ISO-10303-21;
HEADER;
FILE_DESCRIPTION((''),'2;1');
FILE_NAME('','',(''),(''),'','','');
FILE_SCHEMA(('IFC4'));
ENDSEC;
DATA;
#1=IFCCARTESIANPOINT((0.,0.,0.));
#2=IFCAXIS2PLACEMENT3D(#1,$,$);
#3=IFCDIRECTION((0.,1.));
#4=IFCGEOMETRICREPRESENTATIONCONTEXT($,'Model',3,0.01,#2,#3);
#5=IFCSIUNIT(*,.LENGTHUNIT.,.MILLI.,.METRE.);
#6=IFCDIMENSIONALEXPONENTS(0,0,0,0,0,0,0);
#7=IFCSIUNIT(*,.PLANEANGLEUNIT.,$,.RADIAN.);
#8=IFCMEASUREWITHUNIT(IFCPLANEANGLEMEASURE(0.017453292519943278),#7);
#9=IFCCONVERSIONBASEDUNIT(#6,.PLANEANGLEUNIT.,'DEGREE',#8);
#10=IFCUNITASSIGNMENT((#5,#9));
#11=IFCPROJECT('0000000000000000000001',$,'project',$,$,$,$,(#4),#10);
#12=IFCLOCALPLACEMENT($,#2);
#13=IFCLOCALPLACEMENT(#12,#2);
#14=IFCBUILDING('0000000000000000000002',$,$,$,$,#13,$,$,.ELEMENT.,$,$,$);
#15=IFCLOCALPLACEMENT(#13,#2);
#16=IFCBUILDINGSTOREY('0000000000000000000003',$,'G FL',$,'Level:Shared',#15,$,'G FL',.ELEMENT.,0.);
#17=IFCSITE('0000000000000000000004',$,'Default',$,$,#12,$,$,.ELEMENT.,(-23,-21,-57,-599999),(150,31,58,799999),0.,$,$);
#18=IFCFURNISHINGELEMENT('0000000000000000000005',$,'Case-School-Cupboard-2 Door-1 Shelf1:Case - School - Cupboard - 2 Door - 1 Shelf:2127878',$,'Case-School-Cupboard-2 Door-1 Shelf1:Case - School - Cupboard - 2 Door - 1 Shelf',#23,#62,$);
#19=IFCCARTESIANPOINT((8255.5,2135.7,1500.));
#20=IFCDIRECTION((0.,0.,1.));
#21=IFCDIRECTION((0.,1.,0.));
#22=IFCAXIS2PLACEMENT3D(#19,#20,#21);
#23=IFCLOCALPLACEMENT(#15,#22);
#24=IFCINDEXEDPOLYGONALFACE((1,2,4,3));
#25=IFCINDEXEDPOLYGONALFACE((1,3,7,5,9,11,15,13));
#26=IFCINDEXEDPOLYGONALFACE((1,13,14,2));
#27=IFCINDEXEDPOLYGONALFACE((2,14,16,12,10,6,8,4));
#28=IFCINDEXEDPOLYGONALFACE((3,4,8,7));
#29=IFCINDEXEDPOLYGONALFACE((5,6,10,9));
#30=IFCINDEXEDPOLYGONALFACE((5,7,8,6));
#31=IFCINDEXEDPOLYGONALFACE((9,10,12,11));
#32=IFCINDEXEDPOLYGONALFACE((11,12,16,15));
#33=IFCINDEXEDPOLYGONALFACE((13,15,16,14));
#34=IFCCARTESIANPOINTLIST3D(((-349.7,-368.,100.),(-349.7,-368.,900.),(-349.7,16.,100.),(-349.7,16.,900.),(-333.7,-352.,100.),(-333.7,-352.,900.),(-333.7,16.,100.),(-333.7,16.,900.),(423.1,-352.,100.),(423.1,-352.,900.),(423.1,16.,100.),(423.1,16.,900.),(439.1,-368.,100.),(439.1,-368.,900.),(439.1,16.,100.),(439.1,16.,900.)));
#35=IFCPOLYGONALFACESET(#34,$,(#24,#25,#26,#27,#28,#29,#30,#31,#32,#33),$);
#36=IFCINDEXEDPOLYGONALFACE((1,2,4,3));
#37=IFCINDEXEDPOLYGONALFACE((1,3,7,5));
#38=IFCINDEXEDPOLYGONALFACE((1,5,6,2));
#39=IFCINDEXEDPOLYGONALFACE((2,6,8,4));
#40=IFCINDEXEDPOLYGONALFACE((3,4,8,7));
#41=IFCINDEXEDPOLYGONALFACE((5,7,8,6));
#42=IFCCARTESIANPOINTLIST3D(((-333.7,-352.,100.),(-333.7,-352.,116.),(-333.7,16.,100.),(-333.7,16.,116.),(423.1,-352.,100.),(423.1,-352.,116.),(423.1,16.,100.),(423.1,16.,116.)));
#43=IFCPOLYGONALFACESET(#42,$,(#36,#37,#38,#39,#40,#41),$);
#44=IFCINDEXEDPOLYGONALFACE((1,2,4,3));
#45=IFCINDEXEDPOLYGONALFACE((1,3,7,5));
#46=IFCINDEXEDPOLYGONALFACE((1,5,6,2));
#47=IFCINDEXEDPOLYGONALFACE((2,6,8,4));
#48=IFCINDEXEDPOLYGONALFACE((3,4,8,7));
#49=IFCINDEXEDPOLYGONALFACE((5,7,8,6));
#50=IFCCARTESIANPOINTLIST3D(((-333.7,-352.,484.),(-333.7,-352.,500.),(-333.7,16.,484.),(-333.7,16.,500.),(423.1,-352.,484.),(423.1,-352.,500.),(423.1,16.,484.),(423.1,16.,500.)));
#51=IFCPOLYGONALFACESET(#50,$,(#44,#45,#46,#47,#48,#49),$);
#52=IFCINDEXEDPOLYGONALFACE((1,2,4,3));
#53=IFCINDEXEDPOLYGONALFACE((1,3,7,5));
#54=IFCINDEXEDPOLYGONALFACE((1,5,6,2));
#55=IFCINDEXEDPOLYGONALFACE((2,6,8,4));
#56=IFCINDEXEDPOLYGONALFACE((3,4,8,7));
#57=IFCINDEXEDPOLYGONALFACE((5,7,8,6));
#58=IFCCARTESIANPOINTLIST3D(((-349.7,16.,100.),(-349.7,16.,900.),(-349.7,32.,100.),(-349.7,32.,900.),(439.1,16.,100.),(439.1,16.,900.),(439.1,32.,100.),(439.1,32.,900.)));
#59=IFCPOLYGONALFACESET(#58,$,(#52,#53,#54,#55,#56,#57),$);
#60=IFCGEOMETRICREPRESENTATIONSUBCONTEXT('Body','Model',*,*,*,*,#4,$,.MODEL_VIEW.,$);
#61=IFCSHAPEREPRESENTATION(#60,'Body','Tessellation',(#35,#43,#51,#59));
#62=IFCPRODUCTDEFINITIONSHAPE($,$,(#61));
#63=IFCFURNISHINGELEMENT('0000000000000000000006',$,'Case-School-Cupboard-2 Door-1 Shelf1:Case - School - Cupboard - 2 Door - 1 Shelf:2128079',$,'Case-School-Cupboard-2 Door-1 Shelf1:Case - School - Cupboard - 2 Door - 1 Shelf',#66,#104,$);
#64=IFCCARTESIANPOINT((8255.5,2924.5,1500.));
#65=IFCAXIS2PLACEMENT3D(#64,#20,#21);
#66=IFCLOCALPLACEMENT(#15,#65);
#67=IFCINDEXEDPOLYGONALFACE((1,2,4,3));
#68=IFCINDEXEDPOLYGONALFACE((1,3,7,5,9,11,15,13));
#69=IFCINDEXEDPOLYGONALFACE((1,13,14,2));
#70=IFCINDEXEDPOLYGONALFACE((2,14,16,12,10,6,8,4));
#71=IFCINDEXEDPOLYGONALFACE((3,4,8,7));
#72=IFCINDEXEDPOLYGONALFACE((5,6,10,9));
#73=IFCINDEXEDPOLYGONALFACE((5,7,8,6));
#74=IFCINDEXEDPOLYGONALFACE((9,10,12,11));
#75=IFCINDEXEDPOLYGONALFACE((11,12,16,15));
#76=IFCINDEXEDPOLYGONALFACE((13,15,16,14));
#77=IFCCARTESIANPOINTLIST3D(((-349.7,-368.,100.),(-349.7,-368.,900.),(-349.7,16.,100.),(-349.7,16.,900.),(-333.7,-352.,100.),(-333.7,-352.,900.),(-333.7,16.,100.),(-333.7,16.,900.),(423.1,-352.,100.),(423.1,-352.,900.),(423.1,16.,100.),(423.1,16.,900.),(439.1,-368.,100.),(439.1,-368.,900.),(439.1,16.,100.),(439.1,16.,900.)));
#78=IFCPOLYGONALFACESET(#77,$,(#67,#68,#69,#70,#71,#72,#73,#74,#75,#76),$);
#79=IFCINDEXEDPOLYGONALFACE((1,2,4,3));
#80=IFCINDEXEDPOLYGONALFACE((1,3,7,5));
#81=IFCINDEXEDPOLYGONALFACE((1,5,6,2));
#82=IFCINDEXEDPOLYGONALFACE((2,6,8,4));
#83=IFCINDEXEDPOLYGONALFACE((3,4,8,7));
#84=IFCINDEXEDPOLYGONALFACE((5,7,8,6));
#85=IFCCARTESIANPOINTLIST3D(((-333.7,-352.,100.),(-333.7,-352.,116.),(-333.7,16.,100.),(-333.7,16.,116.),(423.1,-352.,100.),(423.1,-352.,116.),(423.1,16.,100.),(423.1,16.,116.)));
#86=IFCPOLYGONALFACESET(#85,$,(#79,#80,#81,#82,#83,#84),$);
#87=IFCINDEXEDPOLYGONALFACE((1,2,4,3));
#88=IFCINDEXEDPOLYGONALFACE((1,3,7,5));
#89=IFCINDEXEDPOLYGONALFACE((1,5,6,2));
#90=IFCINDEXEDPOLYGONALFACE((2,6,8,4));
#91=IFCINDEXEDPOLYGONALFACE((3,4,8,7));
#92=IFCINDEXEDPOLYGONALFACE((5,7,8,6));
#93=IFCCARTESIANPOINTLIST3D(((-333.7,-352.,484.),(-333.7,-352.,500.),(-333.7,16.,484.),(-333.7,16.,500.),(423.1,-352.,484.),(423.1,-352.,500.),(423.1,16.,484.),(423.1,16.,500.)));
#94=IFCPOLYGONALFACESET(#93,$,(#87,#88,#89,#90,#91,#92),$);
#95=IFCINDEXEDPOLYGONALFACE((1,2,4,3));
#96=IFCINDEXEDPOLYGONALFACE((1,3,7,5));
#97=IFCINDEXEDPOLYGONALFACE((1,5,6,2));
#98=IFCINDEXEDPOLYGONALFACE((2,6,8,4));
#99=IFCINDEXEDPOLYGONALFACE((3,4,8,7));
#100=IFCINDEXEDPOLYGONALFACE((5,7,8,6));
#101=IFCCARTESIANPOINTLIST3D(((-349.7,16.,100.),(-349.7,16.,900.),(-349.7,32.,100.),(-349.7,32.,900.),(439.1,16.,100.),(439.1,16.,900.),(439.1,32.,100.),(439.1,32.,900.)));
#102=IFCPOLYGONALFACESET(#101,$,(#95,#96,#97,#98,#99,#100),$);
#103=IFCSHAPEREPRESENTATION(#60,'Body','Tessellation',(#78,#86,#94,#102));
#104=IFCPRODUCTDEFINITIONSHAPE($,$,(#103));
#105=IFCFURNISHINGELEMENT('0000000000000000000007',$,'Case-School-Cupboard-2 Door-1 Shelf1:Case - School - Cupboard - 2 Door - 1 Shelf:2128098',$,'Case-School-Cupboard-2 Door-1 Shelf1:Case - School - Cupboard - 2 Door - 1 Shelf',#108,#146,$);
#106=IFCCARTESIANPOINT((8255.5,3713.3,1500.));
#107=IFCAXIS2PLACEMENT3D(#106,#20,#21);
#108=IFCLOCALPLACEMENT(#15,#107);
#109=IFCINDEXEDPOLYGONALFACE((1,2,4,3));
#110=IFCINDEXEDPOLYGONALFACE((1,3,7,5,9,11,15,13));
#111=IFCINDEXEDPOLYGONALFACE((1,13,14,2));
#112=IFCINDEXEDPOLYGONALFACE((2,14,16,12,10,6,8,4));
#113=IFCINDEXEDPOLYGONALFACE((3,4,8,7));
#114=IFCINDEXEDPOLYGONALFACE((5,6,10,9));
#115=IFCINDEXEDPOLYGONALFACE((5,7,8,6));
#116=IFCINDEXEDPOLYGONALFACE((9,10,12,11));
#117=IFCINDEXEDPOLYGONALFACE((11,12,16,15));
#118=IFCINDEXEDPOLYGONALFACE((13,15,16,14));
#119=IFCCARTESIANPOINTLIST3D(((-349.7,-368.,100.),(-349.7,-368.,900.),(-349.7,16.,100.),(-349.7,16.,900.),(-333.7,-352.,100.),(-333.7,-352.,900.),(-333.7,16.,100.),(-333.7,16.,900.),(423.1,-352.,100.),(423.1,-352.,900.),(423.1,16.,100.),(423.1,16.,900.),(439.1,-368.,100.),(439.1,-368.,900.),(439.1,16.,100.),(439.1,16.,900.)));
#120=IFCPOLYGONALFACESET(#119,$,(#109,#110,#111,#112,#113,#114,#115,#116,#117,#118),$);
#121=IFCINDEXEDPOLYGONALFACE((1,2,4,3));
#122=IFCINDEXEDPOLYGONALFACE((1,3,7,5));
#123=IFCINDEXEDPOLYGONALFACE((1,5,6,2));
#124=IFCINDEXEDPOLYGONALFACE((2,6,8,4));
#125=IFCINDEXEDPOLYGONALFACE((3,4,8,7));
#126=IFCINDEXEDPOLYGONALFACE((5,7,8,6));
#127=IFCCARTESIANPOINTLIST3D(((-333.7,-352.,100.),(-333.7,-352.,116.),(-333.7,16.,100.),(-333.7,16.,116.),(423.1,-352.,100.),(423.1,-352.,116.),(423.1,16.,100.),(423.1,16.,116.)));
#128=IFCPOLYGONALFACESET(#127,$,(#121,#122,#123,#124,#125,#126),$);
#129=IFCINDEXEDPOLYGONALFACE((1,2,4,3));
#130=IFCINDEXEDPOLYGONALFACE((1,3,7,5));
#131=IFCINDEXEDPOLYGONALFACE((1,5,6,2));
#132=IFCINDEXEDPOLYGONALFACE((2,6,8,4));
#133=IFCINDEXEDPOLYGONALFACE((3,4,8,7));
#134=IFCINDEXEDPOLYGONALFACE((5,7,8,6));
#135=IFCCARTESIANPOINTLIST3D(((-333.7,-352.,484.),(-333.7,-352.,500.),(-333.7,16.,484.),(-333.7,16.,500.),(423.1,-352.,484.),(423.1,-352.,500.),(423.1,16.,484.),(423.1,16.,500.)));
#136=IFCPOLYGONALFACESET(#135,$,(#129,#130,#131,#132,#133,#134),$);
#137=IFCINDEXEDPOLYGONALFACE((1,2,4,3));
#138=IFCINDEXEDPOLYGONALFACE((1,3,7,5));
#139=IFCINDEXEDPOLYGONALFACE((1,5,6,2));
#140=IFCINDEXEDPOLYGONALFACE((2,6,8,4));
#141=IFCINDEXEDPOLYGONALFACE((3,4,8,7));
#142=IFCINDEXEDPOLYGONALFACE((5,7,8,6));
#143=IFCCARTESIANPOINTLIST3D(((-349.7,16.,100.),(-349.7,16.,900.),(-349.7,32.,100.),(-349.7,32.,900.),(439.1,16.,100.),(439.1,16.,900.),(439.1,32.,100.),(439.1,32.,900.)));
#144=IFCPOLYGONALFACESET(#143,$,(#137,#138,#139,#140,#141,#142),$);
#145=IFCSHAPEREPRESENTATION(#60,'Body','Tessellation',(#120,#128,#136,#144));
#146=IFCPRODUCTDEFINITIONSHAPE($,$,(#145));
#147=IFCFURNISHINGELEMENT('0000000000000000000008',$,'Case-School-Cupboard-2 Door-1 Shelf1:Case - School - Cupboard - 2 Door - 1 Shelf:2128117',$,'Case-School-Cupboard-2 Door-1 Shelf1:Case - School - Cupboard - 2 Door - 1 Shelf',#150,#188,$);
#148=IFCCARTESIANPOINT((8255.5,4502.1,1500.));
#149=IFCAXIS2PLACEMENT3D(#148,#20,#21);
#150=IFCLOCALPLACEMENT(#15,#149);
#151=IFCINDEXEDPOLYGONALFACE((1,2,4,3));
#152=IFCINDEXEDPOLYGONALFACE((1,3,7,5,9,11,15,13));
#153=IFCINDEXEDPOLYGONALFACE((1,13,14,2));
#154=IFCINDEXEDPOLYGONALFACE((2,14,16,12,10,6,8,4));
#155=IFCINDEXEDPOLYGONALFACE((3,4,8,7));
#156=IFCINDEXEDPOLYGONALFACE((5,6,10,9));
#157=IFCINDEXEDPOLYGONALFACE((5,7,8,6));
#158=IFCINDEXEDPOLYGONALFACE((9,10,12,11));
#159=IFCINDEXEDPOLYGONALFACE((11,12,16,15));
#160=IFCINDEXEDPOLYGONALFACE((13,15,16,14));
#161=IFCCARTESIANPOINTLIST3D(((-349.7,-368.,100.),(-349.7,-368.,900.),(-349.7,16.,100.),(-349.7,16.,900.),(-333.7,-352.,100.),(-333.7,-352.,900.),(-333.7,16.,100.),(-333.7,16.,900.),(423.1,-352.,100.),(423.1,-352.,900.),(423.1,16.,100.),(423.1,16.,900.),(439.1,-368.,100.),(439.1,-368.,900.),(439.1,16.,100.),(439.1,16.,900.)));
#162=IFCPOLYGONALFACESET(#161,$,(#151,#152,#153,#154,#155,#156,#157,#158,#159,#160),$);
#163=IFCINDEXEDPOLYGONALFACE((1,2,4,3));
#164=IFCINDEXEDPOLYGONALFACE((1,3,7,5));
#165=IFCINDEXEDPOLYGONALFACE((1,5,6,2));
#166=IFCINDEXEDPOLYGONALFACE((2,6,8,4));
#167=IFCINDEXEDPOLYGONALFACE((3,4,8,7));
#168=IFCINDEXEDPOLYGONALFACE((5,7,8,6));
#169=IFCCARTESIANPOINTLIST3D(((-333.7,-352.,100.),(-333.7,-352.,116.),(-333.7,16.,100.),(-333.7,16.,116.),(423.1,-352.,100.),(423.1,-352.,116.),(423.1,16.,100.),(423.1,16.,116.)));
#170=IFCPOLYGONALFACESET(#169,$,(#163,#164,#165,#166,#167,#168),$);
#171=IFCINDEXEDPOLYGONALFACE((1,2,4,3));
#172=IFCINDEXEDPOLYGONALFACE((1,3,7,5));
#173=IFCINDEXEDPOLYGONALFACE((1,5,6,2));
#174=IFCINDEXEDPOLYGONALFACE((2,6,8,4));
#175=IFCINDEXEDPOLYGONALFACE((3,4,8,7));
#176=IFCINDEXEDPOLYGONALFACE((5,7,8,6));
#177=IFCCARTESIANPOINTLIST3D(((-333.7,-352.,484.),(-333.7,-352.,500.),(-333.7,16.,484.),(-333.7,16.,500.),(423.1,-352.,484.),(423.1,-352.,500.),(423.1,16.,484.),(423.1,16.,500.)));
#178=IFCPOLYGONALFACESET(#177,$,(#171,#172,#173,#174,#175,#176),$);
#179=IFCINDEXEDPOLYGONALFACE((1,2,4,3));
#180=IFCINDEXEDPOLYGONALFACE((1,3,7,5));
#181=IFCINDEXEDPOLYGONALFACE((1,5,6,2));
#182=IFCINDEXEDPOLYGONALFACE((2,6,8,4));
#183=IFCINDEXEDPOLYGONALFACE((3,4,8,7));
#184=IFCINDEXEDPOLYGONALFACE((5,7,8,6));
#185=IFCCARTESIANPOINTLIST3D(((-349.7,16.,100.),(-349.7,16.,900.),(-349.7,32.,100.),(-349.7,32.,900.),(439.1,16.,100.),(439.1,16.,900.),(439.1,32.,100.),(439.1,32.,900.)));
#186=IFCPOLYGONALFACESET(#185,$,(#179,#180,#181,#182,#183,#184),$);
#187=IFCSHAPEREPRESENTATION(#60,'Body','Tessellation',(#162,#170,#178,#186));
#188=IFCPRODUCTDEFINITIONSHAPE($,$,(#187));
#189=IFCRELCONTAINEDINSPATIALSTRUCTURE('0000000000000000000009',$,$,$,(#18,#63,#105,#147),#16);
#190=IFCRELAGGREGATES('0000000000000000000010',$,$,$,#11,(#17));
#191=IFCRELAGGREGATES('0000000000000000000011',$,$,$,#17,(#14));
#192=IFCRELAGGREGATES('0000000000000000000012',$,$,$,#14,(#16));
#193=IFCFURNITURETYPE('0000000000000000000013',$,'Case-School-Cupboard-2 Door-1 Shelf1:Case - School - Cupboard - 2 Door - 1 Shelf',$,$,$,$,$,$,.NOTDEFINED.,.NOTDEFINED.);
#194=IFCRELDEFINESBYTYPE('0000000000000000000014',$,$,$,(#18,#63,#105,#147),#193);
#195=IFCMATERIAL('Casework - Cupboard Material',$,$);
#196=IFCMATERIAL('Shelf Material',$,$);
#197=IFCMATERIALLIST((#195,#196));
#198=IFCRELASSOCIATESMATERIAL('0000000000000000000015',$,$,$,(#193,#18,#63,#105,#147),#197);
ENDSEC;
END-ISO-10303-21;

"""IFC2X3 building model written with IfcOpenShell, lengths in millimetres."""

from ifc_helpers import new_model, entity, si_unit, converted_unit, direction, frame, frame_2d, origin, place, context, subcontext, project, spatial, polyline, rectangle, outline, extrude, source, transform, mapped, material, material_list, type_object, type_shapes, element, save


model = new_model("IFC2X3")

# Units and contexts
model_context = context("Model", 3, precision=0.01, world=origin(), true_north=direction((0.0, 1.0)))
body_context = subcontext(model_context, "Body", "Model", "MODEL_VIEW")
ifc_project = project(units=[si_unit("LENGTHUNIT", "METRE", prefix="MILLI"), converted_unit("PLANEANGLEUNIT", "DEGREE", entity("IfcPlaneAngleMeasure", 0.017453292519943278), si_unit("PLANEANGLEUNIT", "RADIAN"), dimensions=[0, 0, 0, 0, 0, 0, 0])], contexts=[model_context])

# Site, building, storey
site_placement = place(None, origin())
site = spatial("IfcSite", under=ifc_project, at=site_placement, Name="Default", CompositionType="ELEMENT", RefLatitude=(-23, -21, -57, -599999), RefLongitude=(150, 31, 58, 799999), RefElevation=0.0)
building_placement = place(site_placement, origin())
building = spatial("IfcBuilding", under=site, at=building_placement, CompositionType="ELEMENT")
storey_placement = place(building_placement, origin())
storey = spatial("IfcBuildingStorey", under=building, at=storey_placement, Name="G FL", ObjectType="Level:Shared", LongName="G FL", CompositionType="ELEMENT", Elevation=0.0)

# Furnishing elements
ifc_material_1 = material(Name="Casework - Cupboard Material")
ifc_material_2 = material(Name="Shelf Material")
ifc_material_list = material_list([ifc_material_1, ifc_material_2])
furniture_type = type_object("IfcFurnitureType", Name="Case-School-Cupboard-2 Door-1 Shelf1:Case - School - Cupboard - 2 Door - 1 Shelf", AssemblyPlace="NOTDEFINED", material=ifc_material_list)
shared_shape_1 = source(origin(), body_context, "Body", "SweptSolid", [
    extrude(outline(polyline([(378.4, -188.0), (394.4, -188.0), (394.4, 196.0), (-394.4, 196.0), (-394.4, -188.0), (-378.4, -188.0), (-378.4, 180.0), (378.4, 180.0), (378.4, -188.0)])), frame((44.7, -172.0, 100.0), z_axis=(0.0, 0.0, 1.0), x_axis=(-1.0, 0.0, 0.0)), (0.0, 0.0, 1.0), 800.0),
    extrude(rectangle(XDim=368.0, YDim=756.8, at=frame_2d((0.0, 0.0), x_axis=(1.0, 0.0))), frame((44.7, -168.0, 100.0), z_axis=(0.0, 0.0, 1.0), x_axis=(0.0, -1.0, 0.0)), (0.0, 0.0, 1.0), 16.0),
    extrude(rectangle(XDim=756.8, YDim=368.0, at=frame_2d((0.0, 0.0), x_axis=(1.0, 0.0))), frame((44.7, -168.0, 484.0)), (0.0, 0.0, 1.0), 16.0),
    extrude(rectangle(XDim=788.8, YDim=16.0, at=frame_2d((0.0, 0.0), x_axis=(1.0, 0.0))), frame((44.7, 24.0, 100.0)), (0.0, 0.0, 1.0), 800.0),
])
type_shapes(furniture_type, [shared_shape_1])
for number, where, z_axis, x_axis, name in (
    (1, (8255.5, 2135.7, 1500.0), (0.0, 0.0, 1.0), (0.0, 1.0, 0.0), "Case-School-Cupboard-2 Door-1 Shelf1:Case - School - Cupboard - 2 Door - 1 Shelf:2127878"),
    (2, (8255.5, 2924.5, 1500.0), (0.0, 0.0, 1.0), (0.0, 1.0, 0.0), "Case-School-Cupboard-2 Door-1 Shelf1:Case - School - Cupboard - 2 Door - 1 Shelf:2128079"),
    (3, (8255.5, 3713.3, 1500.0), (0.0, 0.0, 1.0), (0.0, 1.0, 0.0), "Case-School-Cupboard-2 Door-1 Shelf1:Case - School - Cupboard - 2 Door - 1 Shelf:2128098"),
    (4, (8255.5, 4502.1, 1500.0), (0.0, 0.0, 1.0), (0.0, 1.0, 0.0), "Case-School-Cupboard-2 Door-1 Shelf1:Case - School - Cupboard - 2 Door - 1 Shelf:2128117"),
):
    element("IfcFurnishingElement", number, at=place(storey_placement, frame(where, z_axis=z_axis, x_axis=x_axis)), inside=storey, type_object=furniture_type, material=ifc_material_list, Name=name, ObjectType="Case-School-Cupboard-2 Door-1 Shelf1:Case - School - Cupboard - 2 Door - 1 Shelf", context=body_context, shape_type="MappedRepresentation", body=[
        mapped(shared_shape_1, transform((0.0, 0.0, 0.0), scale=1.0)),
    ])

save(model, "model.ifc")
